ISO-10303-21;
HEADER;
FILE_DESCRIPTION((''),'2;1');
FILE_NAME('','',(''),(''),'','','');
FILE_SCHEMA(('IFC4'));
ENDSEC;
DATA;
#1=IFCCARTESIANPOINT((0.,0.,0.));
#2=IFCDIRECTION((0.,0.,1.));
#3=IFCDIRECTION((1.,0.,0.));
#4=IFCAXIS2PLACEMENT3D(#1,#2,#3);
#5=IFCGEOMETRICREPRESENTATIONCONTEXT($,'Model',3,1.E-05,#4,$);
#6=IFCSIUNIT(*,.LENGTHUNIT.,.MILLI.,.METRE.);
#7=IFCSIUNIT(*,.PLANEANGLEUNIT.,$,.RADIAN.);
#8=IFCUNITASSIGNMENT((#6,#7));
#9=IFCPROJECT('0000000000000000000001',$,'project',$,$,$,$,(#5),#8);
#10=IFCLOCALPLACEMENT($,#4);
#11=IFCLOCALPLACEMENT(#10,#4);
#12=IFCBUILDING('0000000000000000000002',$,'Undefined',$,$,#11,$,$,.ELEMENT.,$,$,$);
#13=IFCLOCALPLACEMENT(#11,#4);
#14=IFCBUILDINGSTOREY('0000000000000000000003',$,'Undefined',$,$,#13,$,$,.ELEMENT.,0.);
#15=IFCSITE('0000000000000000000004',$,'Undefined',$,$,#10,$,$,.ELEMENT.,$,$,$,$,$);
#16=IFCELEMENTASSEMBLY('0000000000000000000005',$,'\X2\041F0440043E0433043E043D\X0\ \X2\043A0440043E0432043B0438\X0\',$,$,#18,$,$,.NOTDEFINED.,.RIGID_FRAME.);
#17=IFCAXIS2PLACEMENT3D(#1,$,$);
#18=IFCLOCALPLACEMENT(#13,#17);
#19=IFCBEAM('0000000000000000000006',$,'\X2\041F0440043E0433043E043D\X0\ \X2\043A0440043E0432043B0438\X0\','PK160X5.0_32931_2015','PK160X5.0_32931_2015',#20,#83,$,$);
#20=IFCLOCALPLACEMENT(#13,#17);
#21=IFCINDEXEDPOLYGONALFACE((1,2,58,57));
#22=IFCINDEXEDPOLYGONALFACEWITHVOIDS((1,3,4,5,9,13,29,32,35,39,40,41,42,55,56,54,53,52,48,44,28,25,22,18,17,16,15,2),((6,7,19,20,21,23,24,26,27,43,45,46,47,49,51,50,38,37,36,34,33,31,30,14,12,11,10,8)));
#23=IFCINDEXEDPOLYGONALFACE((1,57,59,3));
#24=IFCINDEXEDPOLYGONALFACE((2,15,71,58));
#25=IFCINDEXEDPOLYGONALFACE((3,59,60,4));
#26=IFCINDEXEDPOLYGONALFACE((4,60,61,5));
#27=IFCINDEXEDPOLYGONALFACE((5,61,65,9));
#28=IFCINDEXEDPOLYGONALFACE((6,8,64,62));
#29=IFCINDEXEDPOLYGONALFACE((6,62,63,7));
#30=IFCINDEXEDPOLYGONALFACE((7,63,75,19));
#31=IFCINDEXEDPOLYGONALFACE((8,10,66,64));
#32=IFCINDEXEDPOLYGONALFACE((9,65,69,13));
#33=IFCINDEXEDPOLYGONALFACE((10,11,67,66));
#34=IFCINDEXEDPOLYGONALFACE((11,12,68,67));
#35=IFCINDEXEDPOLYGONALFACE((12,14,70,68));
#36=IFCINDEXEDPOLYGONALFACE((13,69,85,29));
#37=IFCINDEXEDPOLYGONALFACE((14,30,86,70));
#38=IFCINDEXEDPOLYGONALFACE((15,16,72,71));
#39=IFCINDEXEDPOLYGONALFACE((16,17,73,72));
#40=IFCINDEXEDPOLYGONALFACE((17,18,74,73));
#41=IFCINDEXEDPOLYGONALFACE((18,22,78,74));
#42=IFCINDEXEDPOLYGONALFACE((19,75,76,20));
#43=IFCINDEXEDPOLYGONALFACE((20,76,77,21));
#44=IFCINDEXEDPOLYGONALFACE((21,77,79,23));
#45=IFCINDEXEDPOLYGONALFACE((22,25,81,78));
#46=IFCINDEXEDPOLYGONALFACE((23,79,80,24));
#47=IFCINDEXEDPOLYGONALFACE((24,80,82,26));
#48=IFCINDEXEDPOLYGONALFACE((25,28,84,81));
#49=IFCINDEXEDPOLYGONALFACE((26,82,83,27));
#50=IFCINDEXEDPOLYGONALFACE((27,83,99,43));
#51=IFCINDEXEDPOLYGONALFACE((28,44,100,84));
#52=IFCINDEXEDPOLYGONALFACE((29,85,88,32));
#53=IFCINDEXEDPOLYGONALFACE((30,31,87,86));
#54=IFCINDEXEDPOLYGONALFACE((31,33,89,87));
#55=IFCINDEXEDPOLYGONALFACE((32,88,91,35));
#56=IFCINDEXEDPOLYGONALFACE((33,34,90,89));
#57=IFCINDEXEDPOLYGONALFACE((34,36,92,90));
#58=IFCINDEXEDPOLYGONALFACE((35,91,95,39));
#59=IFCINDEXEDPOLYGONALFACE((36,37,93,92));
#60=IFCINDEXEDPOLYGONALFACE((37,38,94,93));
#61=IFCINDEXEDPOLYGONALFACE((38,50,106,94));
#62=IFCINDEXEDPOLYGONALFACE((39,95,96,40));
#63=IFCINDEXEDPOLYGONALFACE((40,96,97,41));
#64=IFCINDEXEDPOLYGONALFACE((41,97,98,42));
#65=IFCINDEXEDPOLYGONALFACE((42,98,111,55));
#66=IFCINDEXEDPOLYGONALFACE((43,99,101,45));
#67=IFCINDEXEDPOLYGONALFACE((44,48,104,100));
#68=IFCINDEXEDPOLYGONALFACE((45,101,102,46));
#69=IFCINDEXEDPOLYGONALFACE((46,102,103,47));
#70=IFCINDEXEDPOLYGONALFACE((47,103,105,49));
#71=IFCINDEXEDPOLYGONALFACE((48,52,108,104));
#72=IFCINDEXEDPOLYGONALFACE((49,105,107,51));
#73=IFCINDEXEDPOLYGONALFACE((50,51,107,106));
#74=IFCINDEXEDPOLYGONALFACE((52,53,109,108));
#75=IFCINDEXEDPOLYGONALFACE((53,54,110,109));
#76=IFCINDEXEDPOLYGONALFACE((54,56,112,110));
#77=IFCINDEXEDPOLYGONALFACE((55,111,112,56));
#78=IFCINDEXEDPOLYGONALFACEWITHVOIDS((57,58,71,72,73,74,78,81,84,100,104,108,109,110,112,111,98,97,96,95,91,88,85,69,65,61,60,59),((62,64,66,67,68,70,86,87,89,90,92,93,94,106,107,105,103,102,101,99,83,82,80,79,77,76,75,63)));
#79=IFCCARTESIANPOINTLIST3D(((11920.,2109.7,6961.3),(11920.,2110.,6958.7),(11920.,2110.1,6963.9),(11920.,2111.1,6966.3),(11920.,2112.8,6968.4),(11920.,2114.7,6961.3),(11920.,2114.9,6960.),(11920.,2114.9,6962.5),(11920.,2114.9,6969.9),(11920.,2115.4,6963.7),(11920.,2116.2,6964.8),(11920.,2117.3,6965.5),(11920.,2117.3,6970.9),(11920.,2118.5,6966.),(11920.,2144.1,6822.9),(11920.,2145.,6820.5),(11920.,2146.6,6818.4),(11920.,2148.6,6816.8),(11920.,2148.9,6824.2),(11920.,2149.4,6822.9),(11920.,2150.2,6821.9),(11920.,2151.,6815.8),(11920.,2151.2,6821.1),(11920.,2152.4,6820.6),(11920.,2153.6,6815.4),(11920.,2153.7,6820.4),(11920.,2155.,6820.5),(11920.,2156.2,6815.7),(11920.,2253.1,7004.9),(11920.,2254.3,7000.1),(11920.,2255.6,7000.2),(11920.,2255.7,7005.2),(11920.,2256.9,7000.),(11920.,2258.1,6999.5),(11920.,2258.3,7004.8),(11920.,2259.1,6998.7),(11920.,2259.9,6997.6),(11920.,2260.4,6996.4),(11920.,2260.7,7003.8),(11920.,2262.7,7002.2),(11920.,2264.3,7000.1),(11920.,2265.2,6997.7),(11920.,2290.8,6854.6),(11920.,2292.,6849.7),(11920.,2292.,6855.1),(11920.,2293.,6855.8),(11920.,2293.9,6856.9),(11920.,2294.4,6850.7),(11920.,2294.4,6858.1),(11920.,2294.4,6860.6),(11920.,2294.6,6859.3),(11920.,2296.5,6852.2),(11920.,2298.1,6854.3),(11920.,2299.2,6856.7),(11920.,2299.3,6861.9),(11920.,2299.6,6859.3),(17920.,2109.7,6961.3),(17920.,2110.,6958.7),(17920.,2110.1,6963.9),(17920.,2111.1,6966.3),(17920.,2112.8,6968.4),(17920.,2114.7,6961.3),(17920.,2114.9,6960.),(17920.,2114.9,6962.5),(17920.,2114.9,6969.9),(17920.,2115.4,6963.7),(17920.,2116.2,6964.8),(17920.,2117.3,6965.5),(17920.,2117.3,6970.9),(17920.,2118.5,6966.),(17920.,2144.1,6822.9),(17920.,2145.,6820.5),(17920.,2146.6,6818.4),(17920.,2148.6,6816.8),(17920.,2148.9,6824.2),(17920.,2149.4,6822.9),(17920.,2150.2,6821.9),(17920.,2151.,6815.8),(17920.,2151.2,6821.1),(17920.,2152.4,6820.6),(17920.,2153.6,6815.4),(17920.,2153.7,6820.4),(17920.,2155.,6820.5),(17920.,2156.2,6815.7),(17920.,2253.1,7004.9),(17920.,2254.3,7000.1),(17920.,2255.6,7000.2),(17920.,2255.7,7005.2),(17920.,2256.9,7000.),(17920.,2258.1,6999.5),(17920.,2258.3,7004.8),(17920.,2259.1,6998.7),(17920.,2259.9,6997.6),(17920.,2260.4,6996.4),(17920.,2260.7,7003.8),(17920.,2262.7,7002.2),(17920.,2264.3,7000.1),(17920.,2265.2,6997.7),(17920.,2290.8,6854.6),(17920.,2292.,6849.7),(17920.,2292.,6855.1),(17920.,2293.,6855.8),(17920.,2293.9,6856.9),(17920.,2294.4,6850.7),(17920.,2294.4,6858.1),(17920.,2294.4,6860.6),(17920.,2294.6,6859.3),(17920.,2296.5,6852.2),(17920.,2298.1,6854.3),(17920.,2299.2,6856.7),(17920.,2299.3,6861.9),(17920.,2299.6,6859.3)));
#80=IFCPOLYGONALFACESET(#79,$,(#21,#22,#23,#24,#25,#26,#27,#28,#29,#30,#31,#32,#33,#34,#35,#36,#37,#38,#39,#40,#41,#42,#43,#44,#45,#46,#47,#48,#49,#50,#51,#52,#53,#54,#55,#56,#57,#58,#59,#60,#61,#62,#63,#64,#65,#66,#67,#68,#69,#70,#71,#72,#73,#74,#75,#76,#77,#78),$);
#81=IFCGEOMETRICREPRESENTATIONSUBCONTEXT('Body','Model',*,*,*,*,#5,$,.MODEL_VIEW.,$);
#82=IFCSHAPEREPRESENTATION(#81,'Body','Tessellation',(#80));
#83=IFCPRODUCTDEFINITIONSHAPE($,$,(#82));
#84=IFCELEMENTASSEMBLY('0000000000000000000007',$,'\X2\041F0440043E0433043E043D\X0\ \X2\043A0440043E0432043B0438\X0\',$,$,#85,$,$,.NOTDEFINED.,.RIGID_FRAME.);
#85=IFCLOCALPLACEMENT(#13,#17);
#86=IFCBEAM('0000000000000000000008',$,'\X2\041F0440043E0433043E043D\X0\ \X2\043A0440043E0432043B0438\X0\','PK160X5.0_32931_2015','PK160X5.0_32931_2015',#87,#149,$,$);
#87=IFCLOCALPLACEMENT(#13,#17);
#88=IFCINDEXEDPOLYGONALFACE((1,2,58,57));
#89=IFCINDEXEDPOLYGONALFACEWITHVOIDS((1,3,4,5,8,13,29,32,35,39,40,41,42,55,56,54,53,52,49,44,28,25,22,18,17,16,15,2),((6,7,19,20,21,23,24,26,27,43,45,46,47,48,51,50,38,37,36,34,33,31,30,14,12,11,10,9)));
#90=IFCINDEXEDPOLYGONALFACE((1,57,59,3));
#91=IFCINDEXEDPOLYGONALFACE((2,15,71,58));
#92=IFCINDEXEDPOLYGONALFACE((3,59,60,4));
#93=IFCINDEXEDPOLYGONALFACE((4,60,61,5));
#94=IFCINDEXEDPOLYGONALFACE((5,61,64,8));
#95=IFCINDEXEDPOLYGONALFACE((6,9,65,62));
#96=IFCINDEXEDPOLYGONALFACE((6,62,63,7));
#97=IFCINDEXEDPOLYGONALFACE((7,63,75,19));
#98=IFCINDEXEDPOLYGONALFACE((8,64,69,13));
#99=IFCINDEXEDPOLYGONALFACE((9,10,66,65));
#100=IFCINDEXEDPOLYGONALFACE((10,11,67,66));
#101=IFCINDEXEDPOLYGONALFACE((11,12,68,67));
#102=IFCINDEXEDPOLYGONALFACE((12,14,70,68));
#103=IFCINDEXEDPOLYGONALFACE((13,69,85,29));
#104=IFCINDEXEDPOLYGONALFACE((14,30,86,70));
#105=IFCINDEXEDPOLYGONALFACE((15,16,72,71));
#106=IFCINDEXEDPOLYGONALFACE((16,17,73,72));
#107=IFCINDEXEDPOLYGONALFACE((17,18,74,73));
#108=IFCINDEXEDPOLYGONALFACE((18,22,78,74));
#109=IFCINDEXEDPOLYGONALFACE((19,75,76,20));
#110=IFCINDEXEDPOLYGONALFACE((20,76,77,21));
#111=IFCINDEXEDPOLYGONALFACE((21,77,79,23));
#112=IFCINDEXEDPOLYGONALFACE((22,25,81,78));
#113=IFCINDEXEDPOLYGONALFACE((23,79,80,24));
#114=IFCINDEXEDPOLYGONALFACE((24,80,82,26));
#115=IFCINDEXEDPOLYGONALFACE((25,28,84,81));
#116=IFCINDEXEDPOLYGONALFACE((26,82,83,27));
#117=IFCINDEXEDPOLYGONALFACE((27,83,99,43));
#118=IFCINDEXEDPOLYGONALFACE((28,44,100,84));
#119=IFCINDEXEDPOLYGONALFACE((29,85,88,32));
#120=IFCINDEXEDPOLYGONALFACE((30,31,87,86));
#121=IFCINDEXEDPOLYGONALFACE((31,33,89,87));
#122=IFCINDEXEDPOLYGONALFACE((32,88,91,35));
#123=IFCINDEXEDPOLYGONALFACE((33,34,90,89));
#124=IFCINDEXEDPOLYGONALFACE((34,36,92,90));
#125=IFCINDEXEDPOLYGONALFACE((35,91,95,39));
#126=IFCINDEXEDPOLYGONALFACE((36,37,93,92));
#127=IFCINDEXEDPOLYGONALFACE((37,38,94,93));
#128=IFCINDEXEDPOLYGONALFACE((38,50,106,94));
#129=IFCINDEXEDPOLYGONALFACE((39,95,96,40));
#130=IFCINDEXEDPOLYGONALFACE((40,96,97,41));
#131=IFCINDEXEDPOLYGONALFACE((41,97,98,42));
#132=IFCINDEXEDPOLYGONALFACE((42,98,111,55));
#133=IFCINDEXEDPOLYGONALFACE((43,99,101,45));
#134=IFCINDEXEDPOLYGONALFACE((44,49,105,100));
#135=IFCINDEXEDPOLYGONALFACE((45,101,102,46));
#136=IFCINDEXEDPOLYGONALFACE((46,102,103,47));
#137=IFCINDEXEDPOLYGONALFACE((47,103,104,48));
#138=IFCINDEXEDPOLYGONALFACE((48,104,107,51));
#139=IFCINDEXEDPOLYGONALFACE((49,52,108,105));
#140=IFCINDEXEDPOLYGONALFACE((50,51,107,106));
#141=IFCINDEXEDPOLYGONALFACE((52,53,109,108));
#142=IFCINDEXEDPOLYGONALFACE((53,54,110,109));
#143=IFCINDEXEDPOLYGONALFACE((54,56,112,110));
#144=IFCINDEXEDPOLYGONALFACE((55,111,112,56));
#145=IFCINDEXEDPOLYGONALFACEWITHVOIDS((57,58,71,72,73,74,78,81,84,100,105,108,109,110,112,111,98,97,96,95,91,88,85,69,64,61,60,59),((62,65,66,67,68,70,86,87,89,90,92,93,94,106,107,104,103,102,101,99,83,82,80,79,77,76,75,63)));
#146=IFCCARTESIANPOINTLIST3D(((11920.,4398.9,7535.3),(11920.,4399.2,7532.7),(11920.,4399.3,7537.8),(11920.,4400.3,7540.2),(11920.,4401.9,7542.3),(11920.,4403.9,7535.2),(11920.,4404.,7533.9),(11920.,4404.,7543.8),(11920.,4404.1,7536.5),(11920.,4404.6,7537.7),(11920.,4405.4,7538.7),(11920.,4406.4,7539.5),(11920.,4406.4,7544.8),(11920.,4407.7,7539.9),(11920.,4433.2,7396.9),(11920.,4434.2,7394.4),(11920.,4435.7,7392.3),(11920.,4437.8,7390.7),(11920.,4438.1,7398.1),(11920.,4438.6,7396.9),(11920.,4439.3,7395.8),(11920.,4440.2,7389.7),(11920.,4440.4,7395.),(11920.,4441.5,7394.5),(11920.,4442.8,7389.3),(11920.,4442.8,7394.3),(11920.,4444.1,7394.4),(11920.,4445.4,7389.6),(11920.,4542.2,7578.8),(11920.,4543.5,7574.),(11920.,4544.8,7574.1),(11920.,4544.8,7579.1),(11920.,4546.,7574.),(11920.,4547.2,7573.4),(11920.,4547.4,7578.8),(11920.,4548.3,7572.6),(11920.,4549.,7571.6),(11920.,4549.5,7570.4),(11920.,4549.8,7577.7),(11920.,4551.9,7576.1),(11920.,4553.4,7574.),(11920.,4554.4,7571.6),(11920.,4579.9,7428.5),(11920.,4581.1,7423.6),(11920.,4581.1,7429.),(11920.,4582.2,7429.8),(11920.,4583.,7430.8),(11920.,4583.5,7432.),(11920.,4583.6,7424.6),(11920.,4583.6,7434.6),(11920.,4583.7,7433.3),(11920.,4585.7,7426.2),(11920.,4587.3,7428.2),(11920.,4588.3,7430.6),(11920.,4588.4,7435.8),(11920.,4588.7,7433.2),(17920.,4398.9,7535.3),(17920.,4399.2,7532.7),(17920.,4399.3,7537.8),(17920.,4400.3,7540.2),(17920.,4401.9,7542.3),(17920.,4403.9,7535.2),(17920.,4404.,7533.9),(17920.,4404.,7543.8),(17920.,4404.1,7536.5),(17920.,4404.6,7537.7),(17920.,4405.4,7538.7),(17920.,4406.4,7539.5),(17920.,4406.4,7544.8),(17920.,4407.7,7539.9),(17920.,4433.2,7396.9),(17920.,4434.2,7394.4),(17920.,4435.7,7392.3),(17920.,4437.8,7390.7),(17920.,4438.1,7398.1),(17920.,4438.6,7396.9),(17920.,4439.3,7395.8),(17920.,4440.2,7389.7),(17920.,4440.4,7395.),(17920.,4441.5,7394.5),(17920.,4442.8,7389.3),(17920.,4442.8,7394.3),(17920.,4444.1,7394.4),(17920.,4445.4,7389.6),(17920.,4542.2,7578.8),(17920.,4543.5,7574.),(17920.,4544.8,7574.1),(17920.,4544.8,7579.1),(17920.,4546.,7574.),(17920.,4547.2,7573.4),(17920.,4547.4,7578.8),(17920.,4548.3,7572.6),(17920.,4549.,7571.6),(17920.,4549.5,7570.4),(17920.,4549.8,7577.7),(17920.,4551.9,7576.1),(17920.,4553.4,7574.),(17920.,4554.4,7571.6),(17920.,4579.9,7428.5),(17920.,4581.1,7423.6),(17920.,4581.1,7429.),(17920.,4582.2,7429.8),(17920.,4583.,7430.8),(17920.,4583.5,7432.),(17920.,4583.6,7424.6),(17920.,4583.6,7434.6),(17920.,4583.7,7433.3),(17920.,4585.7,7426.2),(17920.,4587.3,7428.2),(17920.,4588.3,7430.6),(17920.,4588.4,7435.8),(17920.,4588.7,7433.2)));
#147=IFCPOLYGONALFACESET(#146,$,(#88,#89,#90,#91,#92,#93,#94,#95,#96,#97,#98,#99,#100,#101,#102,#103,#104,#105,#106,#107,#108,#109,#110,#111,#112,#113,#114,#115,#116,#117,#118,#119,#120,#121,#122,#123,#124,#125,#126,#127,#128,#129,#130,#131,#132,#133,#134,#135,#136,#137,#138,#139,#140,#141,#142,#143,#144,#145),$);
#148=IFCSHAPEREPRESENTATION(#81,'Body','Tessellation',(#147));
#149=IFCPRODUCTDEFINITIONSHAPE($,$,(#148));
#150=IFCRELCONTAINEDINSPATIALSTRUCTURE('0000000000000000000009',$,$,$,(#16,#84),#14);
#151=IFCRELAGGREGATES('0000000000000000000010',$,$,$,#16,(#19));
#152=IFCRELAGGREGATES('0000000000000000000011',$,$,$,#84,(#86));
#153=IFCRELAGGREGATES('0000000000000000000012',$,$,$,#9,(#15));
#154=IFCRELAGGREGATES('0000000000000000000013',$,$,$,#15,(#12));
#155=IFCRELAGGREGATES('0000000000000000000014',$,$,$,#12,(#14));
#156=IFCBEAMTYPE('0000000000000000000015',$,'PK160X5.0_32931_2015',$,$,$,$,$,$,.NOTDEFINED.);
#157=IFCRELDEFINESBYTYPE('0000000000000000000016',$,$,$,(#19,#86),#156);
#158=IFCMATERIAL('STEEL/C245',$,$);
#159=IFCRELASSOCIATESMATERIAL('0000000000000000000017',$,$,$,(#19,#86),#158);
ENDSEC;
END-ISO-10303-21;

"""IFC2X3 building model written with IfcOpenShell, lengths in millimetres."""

from ifc_helpers import new_model, si_unit, frame, origin_with_axes, origin_2d_with_axis, place, context, subcontext, project, spatial, hollow_rectangle, extrude, material, type_object, element, aggregate, save


model = new_model("IFC2X3")

# Units and contexts
model_context = context("Model", 3, precision=1e-05, world=origin_with_axes())
body_context = subcontext(model_context, "Body", "Model", "MODEL_VIEW")
ifc_project = project(units=[si_unit("LENGTHUNIT", "METRE", prefix="MILLI"), si_unit("PLANEANGLEUNIT", "RADIAN")], contexts=[model_context])

# Site, building, storey
site_placement = place(None, origin_with_axes())
site = spatial("IfcSite", under=ifc_project, at=site_placement, Name="Undefined", CompositionType="ELEMENT")
building_placement = place(site_placement, origin_with_axes())
building = spatial("IfcBuilding", under=site, at=building_placement, Name="Undefined", CompositionType="ELEMENT")
storey_placement = place(building_placement, origin_with_axes())
storey = spatial("IfcBuildingStorey", under=building, at=storey_placement, Name="Undefined", CompositionType="ELEMENT", Elevation=0.0)

# Shared definitions
ifc_material = material(Name="STEEL/C245")

# Element assemblies, beams
assembly_1_placement = place(storey_placement, origin_with_axes())
assembly_1 = element("IfcElementAssembly", 1, at=assembly_1_placement, inside=storey, Name="Прогон кровли", AssemblyPlace="NOTDEFINED", PredefinedType="RIGID_FRAME")
beam_type_1 = type_object("IfcBeamType", Name="PK160X5.0_32931_2015", PredefinedType="NOTDEFINED")
beam_1_placement = place(assembly_1_placement, frame((11920.0, 2204.6, 6910.3), z_axis=(0.0, -0.243188, 0.969979), x_axis=(1.0, 0.0, 0.0)))
beam_1 = element("IfcBeam", 2, at=beam_1_placement, type_object=beam_type_1, material=ifc_material, Name="Прогон кровли", Description="PK160X5.0_32931_2015", ObjectType="PK160X5.0_32931_2015", context=body_context, shape_type="SweptSolid", body=[
    extrude(hollow_rectangle(XDim=160.0, YDim=160.0, WallThickness=5.0, InnerFilletRadius=5.0, OuterFilletRadius=10.0, at=origin_2d_with_axis()), frame((6000.0, 0.0, 0.0), z_axis=(-1.0, 0.0, 0.0), x_axis=(0.0, -1.0, 0.0)), (0.0, 0.0, 1.0), 6000.0),
])
aggregate(assembly_1, [beam_1])
assembly_2_placement = place(storey_placement, origin_with_axes())
assembly_2 = element("IfcElementAssembly", 3, at=assembly_2_placement, inside=storey, Name="Прогон кровли", AssemblyPlace="NOTDEFINED", PredefinedType="RIGID_FRAME")
beam_2_placement = place(assembly_2_placement, frame((11920.0, 4493.8, 7484.2), z_axis=(0.0, -0.243188, 0.969979), x_axis=(1.0, 0.0, 0.0)))
beam_2 = element("IfcBeam", 4, at=beam_2_placement, type_object=beam_type_1, material=ifc_material, Name="Прогон кровли", Description="PK160X5.0_32931_2015", ObjectType="PK160X5.0_32931_2015", context=body_context, shape_type="SweptSolid", body=[
    extrude(hollow_rectangle(XDim=160.0, YDim=160.0, WallThickness=5.0, InnerFilletRadius=5.0, OuterFilletRadius=10.0, at=origin_2d_with_axis()), frame((6000.0, 0.0, 0.0), z_axis=(-1.0, 0.0, 0.0), x_axis=(0.0, -1.0, 0.0)), (0.0, 0.0, 1.0), 6000.0),
])
aggregate(assembly_2, [beam_2])

save(model, "model.ifc")
